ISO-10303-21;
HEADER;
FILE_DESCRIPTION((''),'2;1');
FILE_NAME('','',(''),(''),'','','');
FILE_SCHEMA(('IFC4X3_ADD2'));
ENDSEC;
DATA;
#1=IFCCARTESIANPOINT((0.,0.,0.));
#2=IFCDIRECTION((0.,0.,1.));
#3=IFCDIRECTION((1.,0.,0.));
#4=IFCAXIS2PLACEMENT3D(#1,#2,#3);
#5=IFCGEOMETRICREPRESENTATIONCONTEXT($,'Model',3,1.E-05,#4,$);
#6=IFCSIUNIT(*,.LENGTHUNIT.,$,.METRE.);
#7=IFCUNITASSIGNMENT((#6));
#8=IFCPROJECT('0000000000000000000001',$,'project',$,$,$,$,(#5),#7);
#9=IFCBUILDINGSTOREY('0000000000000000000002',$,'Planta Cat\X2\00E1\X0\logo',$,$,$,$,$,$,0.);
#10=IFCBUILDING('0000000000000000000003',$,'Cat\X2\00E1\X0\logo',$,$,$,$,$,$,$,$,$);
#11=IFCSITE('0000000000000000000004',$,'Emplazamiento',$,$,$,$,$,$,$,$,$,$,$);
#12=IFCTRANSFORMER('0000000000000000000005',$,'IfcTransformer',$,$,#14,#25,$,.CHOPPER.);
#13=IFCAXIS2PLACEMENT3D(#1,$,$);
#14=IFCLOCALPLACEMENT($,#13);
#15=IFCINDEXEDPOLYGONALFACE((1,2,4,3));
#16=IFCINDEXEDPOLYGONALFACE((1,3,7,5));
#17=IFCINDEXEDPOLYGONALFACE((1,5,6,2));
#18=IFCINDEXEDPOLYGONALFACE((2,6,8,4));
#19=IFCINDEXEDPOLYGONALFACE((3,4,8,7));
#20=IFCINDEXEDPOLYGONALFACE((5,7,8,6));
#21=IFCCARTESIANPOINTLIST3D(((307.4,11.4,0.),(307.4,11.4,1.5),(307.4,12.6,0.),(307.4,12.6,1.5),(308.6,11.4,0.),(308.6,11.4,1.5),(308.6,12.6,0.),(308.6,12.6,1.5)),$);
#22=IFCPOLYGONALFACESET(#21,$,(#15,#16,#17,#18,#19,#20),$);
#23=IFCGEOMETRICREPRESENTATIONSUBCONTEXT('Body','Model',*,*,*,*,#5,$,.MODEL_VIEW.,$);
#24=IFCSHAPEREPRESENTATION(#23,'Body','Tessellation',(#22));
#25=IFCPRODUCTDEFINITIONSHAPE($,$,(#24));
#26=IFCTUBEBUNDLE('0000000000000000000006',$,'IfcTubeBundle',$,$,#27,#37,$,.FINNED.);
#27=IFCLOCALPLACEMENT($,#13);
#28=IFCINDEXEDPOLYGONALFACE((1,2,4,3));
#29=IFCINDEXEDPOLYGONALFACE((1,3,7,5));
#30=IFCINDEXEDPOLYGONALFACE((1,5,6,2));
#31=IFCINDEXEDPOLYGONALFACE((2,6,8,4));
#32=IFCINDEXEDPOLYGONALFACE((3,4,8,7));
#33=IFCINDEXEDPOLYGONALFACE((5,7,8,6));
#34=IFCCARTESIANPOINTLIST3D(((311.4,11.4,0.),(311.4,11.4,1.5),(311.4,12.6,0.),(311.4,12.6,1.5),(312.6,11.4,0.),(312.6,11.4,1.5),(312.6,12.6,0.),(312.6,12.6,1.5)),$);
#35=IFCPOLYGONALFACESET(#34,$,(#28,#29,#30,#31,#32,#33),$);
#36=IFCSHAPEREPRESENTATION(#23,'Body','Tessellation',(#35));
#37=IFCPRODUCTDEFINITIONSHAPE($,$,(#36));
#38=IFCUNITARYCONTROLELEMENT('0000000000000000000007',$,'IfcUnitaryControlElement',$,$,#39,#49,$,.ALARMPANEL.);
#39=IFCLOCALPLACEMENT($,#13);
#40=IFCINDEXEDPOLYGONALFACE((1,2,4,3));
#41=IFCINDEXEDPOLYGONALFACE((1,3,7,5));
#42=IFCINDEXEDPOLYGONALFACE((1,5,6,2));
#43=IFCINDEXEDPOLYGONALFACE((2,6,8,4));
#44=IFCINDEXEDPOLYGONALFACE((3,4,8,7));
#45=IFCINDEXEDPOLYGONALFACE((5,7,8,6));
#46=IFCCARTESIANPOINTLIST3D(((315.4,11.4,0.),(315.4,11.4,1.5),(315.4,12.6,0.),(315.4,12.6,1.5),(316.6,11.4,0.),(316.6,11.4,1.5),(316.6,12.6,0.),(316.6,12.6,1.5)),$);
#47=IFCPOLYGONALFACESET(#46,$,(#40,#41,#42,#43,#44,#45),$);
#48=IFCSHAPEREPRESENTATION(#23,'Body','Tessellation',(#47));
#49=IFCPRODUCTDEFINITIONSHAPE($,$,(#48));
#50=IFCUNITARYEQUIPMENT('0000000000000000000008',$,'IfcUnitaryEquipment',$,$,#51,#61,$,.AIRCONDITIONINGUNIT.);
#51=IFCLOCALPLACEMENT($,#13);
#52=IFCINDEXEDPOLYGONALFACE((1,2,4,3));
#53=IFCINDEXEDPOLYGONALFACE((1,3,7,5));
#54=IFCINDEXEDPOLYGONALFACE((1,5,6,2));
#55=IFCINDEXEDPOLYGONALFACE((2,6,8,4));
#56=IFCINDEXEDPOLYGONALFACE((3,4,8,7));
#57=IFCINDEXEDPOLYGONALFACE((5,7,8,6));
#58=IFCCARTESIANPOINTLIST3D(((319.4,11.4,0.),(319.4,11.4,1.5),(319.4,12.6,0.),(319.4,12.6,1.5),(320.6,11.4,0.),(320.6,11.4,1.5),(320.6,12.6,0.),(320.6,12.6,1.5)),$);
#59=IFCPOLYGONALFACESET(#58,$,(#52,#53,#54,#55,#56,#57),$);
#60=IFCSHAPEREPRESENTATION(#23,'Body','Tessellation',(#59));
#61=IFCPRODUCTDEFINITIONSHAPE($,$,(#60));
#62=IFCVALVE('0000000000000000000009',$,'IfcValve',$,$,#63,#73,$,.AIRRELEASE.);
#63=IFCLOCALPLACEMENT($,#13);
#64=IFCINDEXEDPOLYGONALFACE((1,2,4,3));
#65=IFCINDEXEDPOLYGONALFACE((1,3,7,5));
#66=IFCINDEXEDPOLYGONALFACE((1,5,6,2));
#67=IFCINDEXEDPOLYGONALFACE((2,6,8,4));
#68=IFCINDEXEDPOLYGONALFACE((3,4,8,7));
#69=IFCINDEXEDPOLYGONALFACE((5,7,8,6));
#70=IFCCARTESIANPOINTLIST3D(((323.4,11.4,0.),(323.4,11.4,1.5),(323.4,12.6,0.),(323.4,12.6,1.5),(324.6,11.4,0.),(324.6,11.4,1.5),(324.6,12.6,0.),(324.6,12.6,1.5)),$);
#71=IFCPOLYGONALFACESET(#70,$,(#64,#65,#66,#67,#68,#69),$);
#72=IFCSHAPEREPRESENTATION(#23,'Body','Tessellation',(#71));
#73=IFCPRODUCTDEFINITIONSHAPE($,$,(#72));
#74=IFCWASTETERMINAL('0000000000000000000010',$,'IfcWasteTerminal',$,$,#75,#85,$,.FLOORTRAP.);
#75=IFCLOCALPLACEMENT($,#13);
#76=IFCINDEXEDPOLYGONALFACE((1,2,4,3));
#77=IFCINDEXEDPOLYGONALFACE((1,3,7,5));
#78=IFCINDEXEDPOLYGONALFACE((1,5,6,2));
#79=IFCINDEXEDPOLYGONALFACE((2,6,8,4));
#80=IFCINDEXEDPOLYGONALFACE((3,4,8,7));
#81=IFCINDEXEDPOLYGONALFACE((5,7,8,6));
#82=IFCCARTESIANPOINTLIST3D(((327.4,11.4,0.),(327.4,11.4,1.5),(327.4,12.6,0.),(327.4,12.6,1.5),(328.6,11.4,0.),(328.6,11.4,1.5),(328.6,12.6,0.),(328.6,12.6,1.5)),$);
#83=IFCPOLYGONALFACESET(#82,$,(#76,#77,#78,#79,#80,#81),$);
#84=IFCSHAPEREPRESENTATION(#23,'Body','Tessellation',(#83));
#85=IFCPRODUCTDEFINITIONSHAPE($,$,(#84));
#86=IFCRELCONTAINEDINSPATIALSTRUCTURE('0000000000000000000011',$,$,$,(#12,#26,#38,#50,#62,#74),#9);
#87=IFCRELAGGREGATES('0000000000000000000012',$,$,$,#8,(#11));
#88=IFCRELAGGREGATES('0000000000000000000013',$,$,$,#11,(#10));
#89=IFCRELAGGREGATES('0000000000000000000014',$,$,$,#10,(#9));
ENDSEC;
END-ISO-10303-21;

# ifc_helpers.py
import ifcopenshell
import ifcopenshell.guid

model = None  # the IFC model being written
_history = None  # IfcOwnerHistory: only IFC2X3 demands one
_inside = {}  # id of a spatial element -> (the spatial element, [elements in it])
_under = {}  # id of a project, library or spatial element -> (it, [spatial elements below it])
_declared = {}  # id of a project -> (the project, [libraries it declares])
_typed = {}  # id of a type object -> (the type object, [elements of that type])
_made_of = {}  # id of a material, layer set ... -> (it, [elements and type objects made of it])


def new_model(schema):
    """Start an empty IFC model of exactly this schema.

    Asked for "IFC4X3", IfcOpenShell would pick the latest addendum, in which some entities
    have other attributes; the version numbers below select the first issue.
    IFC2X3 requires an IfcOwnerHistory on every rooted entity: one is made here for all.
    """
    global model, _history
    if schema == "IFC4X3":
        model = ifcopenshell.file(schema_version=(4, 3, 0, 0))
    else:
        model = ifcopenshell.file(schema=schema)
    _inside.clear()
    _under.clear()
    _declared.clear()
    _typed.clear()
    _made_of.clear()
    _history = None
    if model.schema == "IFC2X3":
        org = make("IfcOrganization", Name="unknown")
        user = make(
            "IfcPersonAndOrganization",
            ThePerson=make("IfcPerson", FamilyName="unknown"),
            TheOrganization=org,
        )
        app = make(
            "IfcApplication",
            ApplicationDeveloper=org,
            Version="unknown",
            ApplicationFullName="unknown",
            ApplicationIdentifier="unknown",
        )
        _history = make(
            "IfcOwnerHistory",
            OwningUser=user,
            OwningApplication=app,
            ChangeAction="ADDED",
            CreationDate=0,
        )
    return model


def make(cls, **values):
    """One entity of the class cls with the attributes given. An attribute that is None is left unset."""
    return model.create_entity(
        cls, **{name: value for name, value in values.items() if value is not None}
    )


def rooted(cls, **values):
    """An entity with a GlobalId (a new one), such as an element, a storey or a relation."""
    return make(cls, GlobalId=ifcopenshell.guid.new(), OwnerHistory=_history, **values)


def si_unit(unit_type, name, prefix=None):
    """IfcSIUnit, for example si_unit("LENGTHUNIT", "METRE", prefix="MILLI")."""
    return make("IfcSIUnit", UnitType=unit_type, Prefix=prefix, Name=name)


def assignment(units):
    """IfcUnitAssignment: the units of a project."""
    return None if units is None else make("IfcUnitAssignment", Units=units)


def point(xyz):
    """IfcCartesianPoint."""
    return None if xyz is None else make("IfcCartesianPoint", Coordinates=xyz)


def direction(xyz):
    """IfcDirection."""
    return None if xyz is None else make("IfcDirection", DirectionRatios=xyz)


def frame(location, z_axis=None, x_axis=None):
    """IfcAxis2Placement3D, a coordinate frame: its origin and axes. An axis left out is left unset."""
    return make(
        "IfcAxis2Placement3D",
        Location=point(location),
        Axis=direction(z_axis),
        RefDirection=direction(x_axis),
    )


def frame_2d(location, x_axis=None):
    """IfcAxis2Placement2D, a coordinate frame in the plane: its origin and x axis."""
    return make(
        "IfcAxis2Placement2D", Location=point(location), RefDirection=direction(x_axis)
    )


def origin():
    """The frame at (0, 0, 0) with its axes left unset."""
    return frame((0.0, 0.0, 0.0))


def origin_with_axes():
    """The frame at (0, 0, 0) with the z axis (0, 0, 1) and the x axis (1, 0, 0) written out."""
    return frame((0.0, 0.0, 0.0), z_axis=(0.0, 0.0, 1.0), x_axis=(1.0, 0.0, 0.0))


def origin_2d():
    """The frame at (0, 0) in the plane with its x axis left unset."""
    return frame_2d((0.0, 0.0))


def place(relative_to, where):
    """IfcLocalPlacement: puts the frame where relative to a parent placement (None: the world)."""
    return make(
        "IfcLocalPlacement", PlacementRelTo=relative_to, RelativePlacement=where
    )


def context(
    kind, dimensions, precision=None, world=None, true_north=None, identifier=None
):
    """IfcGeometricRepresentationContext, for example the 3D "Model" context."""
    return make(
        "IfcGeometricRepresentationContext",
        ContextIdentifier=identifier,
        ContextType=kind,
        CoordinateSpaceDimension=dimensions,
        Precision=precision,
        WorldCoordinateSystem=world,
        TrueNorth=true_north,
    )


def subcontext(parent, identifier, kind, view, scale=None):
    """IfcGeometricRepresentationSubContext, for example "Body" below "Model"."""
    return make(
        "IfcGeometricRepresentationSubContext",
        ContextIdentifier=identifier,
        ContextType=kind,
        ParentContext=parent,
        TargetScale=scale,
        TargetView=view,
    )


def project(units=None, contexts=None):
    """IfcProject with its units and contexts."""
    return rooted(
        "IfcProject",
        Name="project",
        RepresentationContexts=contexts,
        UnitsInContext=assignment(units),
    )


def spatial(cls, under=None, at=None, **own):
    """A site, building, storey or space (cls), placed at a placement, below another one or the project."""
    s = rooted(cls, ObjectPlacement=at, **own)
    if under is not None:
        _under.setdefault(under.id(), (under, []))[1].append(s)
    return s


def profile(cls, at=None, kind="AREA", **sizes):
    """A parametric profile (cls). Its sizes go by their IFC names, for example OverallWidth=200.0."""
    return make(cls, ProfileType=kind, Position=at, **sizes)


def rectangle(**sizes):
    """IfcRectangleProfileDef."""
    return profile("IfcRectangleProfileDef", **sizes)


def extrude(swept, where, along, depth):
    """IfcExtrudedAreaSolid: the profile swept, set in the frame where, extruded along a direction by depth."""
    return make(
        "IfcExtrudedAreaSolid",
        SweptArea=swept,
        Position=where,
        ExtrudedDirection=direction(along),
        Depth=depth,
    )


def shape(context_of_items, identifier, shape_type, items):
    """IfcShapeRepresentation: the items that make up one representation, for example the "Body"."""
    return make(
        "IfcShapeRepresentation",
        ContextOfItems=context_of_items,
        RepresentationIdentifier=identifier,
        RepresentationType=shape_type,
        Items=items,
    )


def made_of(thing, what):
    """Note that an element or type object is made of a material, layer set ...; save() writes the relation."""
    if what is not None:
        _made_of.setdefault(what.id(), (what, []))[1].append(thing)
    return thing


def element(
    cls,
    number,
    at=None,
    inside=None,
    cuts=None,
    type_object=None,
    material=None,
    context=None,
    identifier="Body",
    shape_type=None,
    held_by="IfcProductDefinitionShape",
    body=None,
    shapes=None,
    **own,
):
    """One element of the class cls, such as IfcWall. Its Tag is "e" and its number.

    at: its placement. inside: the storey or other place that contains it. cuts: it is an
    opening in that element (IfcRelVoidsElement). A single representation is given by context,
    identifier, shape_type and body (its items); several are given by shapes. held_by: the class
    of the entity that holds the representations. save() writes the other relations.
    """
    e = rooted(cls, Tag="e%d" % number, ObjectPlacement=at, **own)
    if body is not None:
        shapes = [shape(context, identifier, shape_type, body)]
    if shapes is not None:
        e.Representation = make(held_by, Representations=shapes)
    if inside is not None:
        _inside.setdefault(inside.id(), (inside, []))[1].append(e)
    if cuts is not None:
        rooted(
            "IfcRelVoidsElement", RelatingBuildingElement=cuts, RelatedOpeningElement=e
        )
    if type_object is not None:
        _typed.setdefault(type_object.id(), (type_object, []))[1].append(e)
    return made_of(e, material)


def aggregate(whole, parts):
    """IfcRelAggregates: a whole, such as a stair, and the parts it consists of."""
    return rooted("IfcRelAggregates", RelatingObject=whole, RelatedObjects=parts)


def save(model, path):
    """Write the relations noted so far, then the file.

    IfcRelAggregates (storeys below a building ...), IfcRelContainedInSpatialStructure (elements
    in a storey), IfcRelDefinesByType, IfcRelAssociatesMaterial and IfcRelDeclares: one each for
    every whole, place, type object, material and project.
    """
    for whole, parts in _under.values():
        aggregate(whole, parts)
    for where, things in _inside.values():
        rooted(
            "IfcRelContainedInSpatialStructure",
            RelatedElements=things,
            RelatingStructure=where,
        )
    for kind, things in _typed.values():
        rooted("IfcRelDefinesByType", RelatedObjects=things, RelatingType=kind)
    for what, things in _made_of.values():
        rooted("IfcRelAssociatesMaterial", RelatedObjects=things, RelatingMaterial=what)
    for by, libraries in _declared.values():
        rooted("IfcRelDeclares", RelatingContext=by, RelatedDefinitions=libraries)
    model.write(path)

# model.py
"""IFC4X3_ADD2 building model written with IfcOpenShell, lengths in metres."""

from ifc_helpers import new_model, si_unit, frame, origin, origin_with_axes, origin_2d, place, context, subcontext, project, spatial, rectangle, extrude, element, save


model = new_model("IFC4X3_ADD2")

# Units and contexts
model_context = context("Model", 3, precision=1e-05, world=origin_with_axes())
body_context = subcontext(model_context, "Body", "Model", "MODEL_VIEW")
ifc_project = project(units=[si_unit("LENGTHUNIT", "METRE")], contexts=[model_context])

# Site, building, storey
site = spatial("IfcSite", under=ifc_project, Name="Emplazamiento")
building = spatial("IfcBuilding", under=site, Name="Catálogo")
storey = spatial("IfcBuildingStorey", under=building, Name="Planta Catálogo", Elevation=0.0)

# Transformer
transformer_placement = place(None, frame((308.0, 12.0, 0.0), z_axis=(0.0, 0.0, 1.0), x_axis=(1.0, 0.0, 0.0)))
element("IfcTransformer", 1, at=transformer_placement, inside=storey, Name="IfcTransformer", PredefinedType="CHOPPER", context=body_context, shape_type="SweptSolid", body=[
    extrude(rectangle(XDim=1.2, YDim=1.2, at=origin_2d()), origin(), (0.0, 0.0, 1.0), 1.5),
])

# Tube bundle
tube_bundle_placement = place(None, frame((312.0, 12.0, 0.0), z_axis=(0.0, 0.0, 1.0), x_axis=(1.0, 0.0, 0.0)))
element("IfcTubeBundle", 2, at=tube_bundle_placement, inside=storey, Name="IfcTubeBundle", PredefinedType="FINNED", context=body_context, shape_type="SweptSolid", body=[
    extrude(rectangle(XDim=1.2, YDim=1.2, at=origin_2d()), origin(), (0.0, 0.0, 1.0), 1.5),
])

# Unitary control element
unitary_control_element_placement = place(None, frame((316.0, 12.0, 0.0), z_axis=(0.0, 0.0, 1.0), x_axis=(1.0, 0.0, 0.0)))
element("IfcUnitaryControlElement", 3, at=unitary_control_element_placement, inside=storey, Name="IfcUnitaryControlElement", PredefinedType="ALARMPANEL", context=body_context, shape_type="SweptSolid", body=[
    extrude(rectangle(XDim=1.2, YDim=1.2, at=origin_2d()), origin(), (0.0, 0.0, 1.0), 1.5),
])

# Unitary equipment
unitary_equipment_placement = place(None, frame((320.0, 12.0, 0.0), z_axis=(0.0, 0.0, 1.0), x_axis=(1.0, 0.0, 0.0)))
element("IfcUnitaryEquipment", 4, at=unitary_equipment_placement, inside=storey, Name="IfcUnitaryEquipment", PredefinedType="AIRCONDITIONINGUNIT", context=body_context, shape_type="SweptSolid", body=[
    extrude(rectangle(XDim=1.2, YDim=1.2, at=origin_2d()), origin(), (0.0, 0.0, 1.0), 1.5),
])

# Valve
valve_placement = place(None, frame((324.0, 12.0, 0.0), z_axis=(0.0, 0.0, 1.0), x_axis=(1.0, 0.0, 0.0)))
element("IfcValve", 5, at=valve_placement, inside=storey, Name="IfcValve", PredefinedType="AIRRELEASE", context=body_context, shape_type="SweptSolid", body=[
    extrude(rectangle(XDim=1.2, YDim=1.2, at=origin_2d()), origin(), (0.0, 0.0, 1.0), 1.5),
])

# Waste terminal
waste_terminal_placement = place(None, frame((328.0, 12.0, 0.0), z_axis=(0.0, 0.0, 1.0), x_axis=(1.0, 0.0, 0.0)))
element("IfcWasteTerminal", 6, at=waste_terminal_placement, inside=storey, Name="IfcWasteTerminal", PredefinedType="FLOORTRAP", context=body_context, shape_type="SweptSolid", body=[
    extrude(rectangle(XDim=1.2, YDim=1.2, at=origin_2d()), origin(), (0.0, 0.0, 1.0), 1.5),
])

save(model, "model.ifc")
